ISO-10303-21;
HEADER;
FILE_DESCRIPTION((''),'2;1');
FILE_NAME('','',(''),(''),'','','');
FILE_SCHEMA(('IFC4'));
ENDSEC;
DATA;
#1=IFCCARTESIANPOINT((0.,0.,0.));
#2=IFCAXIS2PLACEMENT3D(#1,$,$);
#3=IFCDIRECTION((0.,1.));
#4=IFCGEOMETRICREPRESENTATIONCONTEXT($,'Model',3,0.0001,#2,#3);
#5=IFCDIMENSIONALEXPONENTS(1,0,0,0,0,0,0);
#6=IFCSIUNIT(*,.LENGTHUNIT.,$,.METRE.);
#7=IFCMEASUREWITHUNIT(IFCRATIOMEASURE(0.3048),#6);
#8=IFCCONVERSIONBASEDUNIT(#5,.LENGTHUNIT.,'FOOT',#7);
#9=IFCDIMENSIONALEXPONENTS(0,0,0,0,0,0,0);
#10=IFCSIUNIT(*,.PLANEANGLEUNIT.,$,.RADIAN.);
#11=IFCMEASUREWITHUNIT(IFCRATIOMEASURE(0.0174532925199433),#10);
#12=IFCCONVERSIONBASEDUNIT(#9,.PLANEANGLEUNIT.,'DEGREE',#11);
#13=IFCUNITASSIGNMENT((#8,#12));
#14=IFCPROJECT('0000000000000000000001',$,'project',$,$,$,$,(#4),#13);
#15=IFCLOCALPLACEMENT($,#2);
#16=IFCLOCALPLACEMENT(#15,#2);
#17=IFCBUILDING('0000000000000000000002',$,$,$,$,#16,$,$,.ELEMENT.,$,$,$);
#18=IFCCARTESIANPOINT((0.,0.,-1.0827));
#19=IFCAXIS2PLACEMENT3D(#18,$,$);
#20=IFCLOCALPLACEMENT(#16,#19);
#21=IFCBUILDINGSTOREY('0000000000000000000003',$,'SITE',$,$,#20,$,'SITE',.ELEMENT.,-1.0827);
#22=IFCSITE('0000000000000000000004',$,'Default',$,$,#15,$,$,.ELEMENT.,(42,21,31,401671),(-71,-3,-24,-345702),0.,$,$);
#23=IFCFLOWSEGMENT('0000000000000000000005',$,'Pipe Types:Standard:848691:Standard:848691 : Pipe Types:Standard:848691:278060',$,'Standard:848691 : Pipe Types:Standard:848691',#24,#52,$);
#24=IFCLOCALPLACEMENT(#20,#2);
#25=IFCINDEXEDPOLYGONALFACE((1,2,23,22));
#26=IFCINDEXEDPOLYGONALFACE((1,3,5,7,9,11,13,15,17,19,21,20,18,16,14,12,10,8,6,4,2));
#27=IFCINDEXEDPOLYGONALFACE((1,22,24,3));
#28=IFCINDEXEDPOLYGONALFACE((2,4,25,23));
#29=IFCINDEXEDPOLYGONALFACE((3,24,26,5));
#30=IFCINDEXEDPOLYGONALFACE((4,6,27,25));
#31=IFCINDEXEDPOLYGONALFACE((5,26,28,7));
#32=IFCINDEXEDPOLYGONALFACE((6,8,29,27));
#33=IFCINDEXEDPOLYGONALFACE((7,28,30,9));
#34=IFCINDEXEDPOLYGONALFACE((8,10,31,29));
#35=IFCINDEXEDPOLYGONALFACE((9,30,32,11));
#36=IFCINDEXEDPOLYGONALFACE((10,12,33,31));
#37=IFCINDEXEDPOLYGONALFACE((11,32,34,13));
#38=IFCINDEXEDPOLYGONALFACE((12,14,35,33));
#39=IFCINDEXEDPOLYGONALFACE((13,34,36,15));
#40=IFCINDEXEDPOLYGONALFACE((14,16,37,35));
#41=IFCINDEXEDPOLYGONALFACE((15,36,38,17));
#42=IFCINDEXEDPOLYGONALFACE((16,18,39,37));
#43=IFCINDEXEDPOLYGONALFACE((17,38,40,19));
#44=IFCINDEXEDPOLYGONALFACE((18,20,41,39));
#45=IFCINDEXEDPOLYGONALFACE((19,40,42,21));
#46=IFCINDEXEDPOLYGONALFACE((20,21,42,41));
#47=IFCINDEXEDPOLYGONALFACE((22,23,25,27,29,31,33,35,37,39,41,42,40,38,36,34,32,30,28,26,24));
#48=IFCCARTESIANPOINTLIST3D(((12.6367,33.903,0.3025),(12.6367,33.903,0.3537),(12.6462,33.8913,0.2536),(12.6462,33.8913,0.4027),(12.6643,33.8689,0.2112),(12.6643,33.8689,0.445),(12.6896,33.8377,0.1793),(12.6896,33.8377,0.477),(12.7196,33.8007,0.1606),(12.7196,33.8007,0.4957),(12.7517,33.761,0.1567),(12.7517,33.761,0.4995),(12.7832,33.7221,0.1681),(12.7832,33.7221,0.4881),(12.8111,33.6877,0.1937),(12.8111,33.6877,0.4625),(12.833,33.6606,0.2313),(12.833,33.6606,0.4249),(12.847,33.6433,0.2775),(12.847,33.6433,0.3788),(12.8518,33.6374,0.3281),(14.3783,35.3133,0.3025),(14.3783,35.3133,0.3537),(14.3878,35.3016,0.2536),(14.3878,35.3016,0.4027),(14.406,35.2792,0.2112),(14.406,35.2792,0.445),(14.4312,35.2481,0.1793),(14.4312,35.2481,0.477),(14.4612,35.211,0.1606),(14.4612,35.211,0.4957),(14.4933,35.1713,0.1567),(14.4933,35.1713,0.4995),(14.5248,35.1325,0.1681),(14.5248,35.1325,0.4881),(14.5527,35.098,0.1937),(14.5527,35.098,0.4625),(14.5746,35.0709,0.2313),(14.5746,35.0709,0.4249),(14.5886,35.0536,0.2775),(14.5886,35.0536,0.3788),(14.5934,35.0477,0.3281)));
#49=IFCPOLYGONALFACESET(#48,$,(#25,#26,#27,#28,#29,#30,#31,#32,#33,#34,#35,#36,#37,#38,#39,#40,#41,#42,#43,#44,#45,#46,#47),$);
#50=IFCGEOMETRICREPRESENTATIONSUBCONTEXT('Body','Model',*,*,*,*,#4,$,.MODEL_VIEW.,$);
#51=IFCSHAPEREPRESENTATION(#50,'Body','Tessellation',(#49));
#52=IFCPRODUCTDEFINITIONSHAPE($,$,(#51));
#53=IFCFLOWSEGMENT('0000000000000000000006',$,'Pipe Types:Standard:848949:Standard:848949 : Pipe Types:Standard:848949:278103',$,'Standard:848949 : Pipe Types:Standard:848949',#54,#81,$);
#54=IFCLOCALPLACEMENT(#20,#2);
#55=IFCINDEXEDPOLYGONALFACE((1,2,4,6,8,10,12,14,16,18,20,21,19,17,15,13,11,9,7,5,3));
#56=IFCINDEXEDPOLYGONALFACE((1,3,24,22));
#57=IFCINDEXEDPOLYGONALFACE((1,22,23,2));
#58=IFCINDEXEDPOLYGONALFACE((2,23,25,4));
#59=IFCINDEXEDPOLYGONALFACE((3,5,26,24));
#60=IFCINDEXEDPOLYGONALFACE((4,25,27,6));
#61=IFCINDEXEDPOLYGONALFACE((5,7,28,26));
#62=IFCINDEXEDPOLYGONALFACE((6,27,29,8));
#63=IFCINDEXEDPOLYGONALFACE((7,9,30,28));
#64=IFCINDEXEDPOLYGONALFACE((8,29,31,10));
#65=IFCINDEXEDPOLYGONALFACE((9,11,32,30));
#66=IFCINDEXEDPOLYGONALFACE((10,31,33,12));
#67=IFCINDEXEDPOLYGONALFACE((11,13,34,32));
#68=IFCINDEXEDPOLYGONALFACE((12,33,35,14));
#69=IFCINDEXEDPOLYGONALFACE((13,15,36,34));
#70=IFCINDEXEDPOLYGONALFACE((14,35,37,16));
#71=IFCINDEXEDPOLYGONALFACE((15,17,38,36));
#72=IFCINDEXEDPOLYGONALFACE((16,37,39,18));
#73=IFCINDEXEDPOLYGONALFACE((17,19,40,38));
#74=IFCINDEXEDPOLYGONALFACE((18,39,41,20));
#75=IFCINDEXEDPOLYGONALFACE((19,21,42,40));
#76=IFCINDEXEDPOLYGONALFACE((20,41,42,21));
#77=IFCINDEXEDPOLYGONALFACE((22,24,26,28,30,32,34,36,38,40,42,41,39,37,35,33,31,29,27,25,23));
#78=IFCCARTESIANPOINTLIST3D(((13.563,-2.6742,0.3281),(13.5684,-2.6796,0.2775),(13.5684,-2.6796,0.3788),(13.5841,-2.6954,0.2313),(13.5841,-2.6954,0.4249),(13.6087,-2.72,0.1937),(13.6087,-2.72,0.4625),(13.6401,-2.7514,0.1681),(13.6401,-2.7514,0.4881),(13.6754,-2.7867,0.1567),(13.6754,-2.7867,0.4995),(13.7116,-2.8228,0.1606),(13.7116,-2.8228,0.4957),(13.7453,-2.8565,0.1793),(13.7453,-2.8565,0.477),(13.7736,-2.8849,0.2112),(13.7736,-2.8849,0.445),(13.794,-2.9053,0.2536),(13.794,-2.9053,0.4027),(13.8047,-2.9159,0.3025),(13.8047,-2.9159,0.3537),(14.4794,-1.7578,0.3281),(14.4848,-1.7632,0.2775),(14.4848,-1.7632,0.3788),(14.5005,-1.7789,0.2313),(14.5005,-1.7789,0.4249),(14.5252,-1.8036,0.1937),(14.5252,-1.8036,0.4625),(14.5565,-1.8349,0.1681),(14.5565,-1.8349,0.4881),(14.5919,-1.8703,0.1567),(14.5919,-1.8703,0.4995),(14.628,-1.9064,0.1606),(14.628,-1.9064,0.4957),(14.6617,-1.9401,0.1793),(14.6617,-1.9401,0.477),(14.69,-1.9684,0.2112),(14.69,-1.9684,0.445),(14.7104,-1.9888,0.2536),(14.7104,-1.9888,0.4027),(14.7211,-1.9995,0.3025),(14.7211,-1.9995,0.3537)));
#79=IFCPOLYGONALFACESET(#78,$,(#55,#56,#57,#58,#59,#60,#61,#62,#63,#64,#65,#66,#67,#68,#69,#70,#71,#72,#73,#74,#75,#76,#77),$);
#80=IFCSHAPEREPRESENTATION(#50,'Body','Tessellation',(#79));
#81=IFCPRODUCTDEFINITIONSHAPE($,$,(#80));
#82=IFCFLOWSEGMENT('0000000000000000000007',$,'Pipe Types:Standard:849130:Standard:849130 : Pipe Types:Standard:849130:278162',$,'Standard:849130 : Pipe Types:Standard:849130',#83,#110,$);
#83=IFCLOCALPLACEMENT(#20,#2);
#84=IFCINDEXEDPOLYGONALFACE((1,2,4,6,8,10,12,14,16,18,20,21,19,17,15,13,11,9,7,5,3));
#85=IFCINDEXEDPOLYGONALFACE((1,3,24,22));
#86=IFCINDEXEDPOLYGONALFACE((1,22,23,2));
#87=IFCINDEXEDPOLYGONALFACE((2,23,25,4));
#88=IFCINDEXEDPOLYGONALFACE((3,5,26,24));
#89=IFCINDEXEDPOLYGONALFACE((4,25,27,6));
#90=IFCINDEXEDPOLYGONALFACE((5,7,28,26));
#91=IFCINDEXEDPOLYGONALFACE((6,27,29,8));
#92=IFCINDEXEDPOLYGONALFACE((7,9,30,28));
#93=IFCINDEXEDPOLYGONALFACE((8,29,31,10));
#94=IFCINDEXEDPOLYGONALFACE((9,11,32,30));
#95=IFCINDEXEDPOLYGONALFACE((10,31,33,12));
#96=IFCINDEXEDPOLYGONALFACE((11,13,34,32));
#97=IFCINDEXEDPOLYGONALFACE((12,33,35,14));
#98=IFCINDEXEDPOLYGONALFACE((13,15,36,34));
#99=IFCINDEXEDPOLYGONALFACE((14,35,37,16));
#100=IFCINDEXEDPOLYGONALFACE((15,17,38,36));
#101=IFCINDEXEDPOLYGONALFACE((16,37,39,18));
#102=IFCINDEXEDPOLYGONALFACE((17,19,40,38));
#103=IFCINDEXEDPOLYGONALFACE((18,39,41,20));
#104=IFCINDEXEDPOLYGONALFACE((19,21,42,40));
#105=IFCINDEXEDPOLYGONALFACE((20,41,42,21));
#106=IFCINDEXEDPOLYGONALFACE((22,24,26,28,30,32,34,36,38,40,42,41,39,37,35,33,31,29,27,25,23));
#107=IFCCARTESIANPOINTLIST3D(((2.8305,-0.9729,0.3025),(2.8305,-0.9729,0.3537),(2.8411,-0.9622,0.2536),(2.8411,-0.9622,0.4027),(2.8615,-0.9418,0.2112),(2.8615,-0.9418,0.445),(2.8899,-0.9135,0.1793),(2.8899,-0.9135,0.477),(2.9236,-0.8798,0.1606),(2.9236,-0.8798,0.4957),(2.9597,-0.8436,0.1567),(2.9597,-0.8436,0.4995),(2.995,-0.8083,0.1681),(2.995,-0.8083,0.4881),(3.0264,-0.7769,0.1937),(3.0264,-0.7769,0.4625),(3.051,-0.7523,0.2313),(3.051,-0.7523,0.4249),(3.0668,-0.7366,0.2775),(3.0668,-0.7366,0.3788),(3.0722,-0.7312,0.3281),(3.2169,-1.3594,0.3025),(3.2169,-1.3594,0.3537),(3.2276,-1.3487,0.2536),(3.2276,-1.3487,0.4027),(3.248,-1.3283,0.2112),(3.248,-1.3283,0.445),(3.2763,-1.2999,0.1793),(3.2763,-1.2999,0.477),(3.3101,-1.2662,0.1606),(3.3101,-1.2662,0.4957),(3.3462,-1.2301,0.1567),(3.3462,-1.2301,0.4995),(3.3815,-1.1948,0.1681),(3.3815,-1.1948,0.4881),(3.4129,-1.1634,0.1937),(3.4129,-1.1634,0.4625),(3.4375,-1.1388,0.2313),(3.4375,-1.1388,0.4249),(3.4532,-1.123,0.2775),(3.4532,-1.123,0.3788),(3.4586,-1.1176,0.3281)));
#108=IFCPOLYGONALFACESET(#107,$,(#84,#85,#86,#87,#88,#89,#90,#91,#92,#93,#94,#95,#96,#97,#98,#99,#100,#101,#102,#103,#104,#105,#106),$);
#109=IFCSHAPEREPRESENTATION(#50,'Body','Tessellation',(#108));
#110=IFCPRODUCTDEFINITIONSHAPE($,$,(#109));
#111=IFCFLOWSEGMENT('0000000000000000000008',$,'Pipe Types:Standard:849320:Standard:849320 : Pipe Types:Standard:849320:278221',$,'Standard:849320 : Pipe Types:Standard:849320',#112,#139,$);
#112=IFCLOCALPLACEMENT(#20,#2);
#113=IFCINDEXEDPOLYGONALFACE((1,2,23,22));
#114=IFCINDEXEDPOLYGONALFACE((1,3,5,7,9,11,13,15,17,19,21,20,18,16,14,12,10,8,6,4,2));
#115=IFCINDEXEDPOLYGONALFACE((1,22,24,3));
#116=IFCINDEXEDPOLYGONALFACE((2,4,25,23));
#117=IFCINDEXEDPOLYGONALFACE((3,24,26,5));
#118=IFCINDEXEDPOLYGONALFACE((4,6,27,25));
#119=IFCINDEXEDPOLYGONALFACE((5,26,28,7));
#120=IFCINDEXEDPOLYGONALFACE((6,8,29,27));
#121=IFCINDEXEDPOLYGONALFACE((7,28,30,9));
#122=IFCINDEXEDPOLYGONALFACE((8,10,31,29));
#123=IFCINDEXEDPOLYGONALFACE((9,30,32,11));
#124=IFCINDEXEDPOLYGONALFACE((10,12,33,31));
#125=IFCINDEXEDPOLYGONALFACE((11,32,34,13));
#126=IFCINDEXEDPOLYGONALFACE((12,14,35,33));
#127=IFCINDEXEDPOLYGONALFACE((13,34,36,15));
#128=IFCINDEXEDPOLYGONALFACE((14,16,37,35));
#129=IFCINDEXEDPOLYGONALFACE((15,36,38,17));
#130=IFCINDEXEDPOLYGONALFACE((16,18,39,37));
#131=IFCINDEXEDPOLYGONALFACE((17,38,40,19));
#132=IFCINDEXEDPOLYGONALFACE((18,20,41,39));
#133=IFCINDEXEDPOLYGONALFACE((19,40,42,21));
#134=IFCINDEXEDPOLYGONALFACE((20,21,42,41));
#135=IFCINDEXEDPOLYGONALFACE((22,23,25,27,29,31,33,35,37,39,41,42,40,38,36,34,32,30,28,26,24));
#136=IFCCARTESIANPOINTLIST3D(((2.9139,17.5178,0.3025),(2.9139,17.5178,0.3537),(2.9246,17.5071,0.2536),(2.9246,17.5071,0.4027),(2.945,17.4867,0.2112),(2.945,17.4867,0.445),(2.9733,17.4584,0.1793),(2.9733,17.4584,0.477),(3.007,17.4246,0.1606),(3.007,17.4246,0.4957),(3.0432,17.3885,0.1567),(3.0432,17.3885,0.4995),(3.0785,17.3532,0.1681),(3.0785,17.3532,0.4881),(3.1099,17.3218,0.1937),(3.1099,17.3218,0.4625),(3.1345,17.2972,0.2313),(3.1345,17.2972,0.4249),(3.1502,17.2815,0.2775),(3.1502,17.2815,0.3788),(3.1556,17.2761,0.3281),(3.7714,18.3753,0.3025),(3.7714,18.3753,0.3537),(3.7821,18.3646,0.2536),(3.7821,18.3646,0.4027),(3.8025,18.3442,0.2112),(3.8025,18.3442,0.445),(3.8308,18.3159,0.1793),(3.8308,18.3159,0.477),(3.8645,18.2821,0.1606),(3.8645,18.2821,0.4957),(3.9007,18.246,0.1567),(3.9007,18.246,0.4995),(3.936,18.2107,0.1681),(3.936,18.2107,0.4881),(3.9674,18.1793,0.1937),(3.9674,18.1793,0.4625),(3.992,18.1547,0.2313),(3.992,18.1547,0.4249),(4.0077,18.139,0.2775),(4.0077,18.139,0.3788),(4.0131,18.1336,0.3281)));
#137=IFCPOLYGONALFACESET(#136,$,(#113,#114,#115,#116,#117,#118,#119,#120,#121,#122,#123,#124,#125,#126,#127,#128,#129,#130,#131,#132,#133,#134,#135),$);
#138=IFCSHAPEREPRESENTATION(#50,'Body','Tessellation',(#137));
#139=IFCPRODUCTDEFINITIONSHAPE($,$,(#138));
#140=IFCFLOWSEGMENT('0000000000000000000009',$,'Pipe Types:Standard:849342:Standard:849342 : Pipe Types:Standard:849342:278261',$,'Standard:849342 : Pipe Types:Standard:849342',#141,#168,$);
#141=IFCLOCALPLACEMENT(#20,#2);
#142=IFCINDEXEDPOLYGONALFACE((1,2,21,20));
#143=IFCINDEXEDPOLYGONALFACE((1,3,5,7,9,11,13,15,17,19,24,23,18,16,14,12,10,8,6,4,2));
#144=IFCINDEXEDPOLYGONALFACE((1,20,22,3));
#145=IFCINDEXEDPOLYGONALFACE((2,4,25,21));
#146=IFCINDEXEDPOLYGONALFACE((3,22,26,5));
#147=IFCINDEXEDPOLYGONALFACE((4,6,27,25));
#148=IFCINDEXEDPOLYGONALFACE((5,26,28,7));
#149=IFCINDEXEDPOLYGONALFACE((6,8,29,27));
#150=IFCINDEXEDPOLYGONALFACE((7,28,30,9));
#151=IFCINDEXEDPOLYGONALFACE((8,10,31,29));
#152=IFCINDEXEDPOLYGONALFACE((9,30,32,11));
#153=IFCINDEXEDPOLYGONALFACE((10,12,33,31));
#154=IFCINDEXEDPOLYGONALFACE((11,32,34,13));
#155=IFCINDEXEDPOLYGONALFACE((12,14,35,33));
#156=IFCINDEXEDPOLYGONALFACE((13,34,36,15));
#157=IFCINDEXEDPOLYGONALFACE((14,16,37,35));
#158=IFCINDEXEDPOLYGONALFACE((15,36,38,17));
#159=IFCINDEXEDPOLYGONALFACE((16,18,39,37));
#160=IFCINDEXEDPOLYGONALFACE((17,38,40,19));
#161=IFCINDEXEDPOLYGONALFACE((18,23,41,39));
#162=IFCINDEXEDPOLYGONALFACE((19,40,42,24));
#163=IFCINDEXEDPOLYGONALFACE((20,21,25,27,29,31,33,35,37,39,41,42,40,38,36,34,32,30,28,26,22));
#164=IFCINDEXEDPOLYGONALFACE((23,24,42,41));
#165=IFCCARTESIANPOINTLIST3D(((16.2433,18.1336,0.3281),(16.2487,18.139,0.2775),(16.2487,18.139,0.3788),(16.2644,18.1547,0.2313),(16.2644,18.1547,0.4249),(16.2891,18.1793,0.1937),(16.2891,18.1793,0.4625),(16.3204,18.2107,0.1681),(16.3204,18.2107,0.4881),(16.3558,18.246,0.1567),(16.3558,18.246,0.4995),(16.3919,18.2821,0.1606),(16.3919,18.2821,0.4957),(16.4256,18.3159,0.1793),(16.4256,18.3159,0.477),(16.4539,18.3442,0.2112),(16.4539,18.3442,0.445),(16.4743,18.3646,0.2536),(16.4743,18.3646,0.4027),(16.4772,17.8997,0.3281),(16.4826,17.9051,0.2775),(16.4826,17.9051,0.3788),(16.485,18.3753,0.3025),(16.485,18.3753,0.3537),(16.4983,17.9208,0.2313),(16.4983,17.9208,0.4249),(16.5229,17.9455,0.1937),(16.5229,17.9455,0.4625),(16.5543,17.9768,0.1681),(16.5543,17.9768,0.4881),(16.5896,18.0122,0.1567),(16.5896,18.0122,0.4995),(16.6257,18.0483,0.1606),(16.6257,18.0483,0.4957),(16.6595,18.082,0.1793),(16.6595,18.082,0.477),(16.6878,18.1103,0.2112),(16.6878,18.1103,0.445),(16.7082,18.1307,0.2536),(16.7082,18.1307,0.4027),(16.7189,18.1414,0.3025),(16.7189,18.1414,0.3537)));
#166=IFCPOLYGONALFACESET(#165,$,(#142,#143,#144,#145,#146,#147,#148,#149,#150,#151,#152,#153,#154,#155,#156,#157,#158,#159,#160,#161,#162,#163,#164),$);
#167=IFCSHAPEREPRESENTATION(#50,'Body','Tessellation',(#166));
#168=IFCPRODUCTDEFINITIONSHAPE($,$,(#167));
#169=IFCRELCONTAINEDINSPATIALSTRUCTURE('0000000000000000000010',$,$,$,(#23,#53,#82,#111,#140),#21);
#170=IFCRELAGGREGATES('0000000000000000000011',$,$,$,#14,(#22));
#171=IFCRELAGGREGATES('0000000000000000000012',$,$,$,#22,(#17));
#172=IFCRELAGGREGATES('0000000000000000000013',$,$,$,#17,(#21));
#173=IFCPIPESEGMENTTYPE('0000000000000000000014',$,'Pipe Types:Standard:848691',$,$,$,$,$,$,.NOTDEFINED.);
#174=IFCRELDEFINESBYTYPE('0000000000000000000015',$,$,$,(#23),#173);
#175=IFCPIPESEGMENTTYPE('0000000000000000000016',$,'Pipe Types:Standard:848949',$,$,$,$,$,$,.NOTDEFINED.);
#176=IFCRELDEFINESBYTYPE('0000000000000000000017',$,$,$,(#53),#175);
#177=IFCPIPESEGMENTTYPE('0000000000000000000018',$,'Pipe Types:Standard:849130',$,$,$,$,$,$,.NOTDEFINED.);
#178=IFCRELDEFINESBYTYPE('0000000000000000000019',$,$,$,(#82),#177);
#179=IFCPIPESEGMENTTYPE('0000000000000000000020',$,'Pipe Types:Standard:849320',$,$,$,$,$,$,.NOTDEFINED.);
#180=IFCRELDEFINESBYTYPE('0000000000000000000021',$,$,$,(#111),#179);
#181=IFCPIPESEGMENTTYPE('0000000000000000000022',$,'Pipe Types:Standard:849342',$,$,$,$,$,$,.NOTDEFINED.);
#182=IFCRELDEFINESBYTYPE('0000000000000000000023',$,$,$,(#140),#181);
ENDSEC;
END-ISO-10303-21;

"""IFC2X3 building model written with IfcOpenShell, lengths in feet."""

from ifc_helpers import new_model, entity, si_unit, converted_unit, direction, frame, frame_2d, origin, place, context, subcontext, project, spatial, circle, extrude, source, transform, mapped, type_object, type_shapes, element, save


model = new_model("IFC2X3")

# Units and contexts
model_context = context("Model", 3, precision=0.0001, world=origin(), true_north=direction((0.0, 1.0)))
body_context = subcontext(model_context, "Body", "Model", "MODEL_VIEW")
ifc_project = project(units=[converted_unit("LENGTHUNIT", "FOOT", entity("IfcRatioMeasure", 0.3048), si_unit("LENGTHUNIT", "METRE"), dimensions=[1, 0, 0, 0, 0, 0, 0]), converted_unit("PLANEANGLEUNIT", "DEGREE", entity("IfcRatioMeasure", 0.0174532925199433), si_unit("PLANEANGLEUNIT", "RADIAN"), dimensions=[0, 0, 0, 0, 0, 0, 0])], contexts=[model_context])

# Site, building, storey
site_placement = place(None, origin())
site = spatial("IfcSite", under=ifc_project, at=site_placement, Name="Default", CompositionType="ELEMENT", RefLatitude=(42, 21, 31, 401671), RefLongitude=(-71, -3, -24, -345702), RefElevation=0.0)
building_placement = place(site_placement, origin())
building = spatial("IfcBuilding", under=site, at=building_placement, CompositionType="ELEMENT")
storey_placement = place(building_placement, frame((0.0, 0.0, -1.0827)))
storey = spatial("IfcBuildingStorey", under=building, at=storey_placement, Name="SITE", LongName="SITE", CompositionType="ELEMENT", Elevation=-1.0827)

# Flow segments
pipe_segment_type_1 = type_object("IfcPipeSegmentType", Name="Pipe Types:Standard:848691", PredefinedType="NOTDEFINED")
shared_shape_1 = source(origin(), body_context, "Body", "SweptSolid", [
    extrude(circle(Radius=0.1719, at=frame_2d((0.0, 0.0), x_axis=(1.0, 0.0))), frame((12.7436, 33.7709, -0.7546), z_axis=(0.777146, 0.62932, 0.0), x_axis=(0.62932, -0.777146, 0.0)), (0.0, 0.0, 1.0), 2.241),
])
type_shapes(pipe_segment_type_1, [shared_shape_1])
flow_segment_1_placement = place(storey_placement, frame((0.0, 0.0, 1.0827)))
element("IfcFlowSegment", 1, at=flow_segment_1_placement, inside=storey, type_object=pipe_segment_type_1, Name="Pipe Types:Standard:848691:Standard:848691 : Pipe Types:Standard:848691:278060", ObjectType="Standard:848691 : Pipe Types:Standard:848691", context=body_context, shape_type="MappedRepresentation", body=[
    mapped(shared_shape_1, transform((0.0, 0.0, 0.0), scale=1.0)),
])
pipe_segment_type_2 = type_object("IfcPipeSegmentType", Name="Pipe Types:Standard:848949", PredefinedType="NOTDEFINED")
shared_shape_2 = source(origin(), body_context, "Body", "SweptSolid", [
    extrude(circle(Radius=0.1719, at=frame_2d((0.0, 0.0), x_axis=(1.0, 0.0))), frame((13.6845, -2.7958, -0.7546), z_axis=(0.707107, 0.707107, 0.0), x_axis=(-0.707107, 0.707107, 0.0)), (0.0, 0.0, 1.0), 1.296),
])
type_shapes(pipe_segment_type_2, [shared_shape_2])
flow_segment_2_placement = place(storey_placement, frame((0.0, 0.0, 1.0827)))
element("IfcFlowSegment", 2, at=flow_segment_2_placement, inside=storey, type_object=pipe_segment_type_2, Name="Pipe Types:Standard:848949:Standard:848949 : Pipe Types:Standard:848949:278103", ObjectType="Standard:848949 : Pipe Types:Standard:848949", context=body_context, shape_type="MappedRepresentation", body=[
    mapped(shared_shape_2, transform((0.0, 0.0, 0.0), scale=1.0)),
])
pipe_segment_type_3 = type_object("IfcPipeSegmentType", Name="Pipe Types:Standard:849130", PredefinedType="NOTDEFINED")
shared_shape_3 = source(origin(), body_context, "Body", "SweptSolid", [
    extrude(circle(Radius=0.1719, at=frame_2d((0.0, 0.0), x_axis=(1.0, 0.0))), frame((2.9506, -0.8527, -0.7546), z_axis=(0.707107, -0.707107, 0.0), x_axis=(0.707107, 0.707107, 0.0)), (0.0, 0.0, 1.0), 0.5465),
])
type_shapes(pipe_segment_type_3, [shared_shape_3])
flow_segment_3_placement = place(storey_placement, frame((0.0, 0.0, 1.0827)))
element("IfcFlowSegment", 3, at=flow_segment_3_placement, inside=storey, type_object=pipe_segment_type_3, Name="Pipe Types:Standard:849130:Standard:849130 : Pipe Types:Standard:849130:278162", ObjectType="Standard:849130 : Pipe Types:Standard:849130", context=body_context, shape_type="MappedRepresentation", body=[
    mapped(shared_shape_3, transform((0.0, 0.0, 0.0), scale=1.0)),
])
pipe_segment_type_4 = type_object("IfcPipeSegmentType", Name="Pipe Types:Standard:849320", PredefinedType="NOTDEFINED")
shared_shape_4 = source(origin(), body_context, "Body", "SweptSolid", [
    extrude(circle(Radius=0.1719, at=frame_2d((0.0, 0.0), x_axis=(1.0, 0.0))), frame((3.0341, 17.3976, -0.7546), z_axis=(0.707107, 0.707107, 0.0), x_axis=(0.707107, -0.707107, 0.0)), (0.0, 0.0, 1.0), 1.2127),
])
type_shapes(pipe_segment_type_4, [shared_shape_4])
flow_segment_4_placement = place(storey_placement, frame((0.0, 0.0, 1.0827)))
element("IfcFlowSegment", 4, at=flow_segment_4_placement, inside=storey, type_object=pipe_segment_type_4, Name="Pipe Types:Standard:849320:Standard:849320 : Pipe Types:Standard:849320:278221", ObjectType="Standard:849320 : Pipe Types:Standard:849320", context=body_context, shape_type="MappedRepresentation", body=[
    mapped(shared_shape_4, transform((0.0, 0.0, 0.0), scale=1.0)),
])
pipe_segment_type_5 = type_object("IfcPipeSegmentType", Name="Pipe Types:Standard:849342", PredefinedType="NOTDEFINED")
shared_shape_5 = source(origin(), body_context, "Body", "SweptSolid", [
    extrude(circle(Radius=0.1719, at=frame_2d((0.0, 0.0), x_axis=(1.0, 0.0))), frame((16.3648, 18.2551, -0.7546), z_axis=(0.707107, -0.707107, 0.0), x_axis=(-0.707107, -0.707107, 0.0)), (0.0, 0.0, 1.0), 0.3307),
])
type_shapes(pipe_segment_type_5, [shared_shape_5])
flow_segment_5_placement = place(storey_placement, frame((0.0, 0.0, 1.0827)))
element("IfcFlowSegment", 5, at=flow_segment_5_placement, inside=storey, type_object=pipe_segment_type_5, Name="Pipe Types:Standard:849342:Standard:849342 : Pipe Types:Standard:849342:278261", ObjectType="Standard:849342 : Pipe Types:Standard:849342", context=body_context, shape_type="MappedRepresentation", body=[
    mapped(shared_shape_5, transform((0.0, 0.0, 0.0), scale=1.0)),
])

save(model, "model.ifc")
